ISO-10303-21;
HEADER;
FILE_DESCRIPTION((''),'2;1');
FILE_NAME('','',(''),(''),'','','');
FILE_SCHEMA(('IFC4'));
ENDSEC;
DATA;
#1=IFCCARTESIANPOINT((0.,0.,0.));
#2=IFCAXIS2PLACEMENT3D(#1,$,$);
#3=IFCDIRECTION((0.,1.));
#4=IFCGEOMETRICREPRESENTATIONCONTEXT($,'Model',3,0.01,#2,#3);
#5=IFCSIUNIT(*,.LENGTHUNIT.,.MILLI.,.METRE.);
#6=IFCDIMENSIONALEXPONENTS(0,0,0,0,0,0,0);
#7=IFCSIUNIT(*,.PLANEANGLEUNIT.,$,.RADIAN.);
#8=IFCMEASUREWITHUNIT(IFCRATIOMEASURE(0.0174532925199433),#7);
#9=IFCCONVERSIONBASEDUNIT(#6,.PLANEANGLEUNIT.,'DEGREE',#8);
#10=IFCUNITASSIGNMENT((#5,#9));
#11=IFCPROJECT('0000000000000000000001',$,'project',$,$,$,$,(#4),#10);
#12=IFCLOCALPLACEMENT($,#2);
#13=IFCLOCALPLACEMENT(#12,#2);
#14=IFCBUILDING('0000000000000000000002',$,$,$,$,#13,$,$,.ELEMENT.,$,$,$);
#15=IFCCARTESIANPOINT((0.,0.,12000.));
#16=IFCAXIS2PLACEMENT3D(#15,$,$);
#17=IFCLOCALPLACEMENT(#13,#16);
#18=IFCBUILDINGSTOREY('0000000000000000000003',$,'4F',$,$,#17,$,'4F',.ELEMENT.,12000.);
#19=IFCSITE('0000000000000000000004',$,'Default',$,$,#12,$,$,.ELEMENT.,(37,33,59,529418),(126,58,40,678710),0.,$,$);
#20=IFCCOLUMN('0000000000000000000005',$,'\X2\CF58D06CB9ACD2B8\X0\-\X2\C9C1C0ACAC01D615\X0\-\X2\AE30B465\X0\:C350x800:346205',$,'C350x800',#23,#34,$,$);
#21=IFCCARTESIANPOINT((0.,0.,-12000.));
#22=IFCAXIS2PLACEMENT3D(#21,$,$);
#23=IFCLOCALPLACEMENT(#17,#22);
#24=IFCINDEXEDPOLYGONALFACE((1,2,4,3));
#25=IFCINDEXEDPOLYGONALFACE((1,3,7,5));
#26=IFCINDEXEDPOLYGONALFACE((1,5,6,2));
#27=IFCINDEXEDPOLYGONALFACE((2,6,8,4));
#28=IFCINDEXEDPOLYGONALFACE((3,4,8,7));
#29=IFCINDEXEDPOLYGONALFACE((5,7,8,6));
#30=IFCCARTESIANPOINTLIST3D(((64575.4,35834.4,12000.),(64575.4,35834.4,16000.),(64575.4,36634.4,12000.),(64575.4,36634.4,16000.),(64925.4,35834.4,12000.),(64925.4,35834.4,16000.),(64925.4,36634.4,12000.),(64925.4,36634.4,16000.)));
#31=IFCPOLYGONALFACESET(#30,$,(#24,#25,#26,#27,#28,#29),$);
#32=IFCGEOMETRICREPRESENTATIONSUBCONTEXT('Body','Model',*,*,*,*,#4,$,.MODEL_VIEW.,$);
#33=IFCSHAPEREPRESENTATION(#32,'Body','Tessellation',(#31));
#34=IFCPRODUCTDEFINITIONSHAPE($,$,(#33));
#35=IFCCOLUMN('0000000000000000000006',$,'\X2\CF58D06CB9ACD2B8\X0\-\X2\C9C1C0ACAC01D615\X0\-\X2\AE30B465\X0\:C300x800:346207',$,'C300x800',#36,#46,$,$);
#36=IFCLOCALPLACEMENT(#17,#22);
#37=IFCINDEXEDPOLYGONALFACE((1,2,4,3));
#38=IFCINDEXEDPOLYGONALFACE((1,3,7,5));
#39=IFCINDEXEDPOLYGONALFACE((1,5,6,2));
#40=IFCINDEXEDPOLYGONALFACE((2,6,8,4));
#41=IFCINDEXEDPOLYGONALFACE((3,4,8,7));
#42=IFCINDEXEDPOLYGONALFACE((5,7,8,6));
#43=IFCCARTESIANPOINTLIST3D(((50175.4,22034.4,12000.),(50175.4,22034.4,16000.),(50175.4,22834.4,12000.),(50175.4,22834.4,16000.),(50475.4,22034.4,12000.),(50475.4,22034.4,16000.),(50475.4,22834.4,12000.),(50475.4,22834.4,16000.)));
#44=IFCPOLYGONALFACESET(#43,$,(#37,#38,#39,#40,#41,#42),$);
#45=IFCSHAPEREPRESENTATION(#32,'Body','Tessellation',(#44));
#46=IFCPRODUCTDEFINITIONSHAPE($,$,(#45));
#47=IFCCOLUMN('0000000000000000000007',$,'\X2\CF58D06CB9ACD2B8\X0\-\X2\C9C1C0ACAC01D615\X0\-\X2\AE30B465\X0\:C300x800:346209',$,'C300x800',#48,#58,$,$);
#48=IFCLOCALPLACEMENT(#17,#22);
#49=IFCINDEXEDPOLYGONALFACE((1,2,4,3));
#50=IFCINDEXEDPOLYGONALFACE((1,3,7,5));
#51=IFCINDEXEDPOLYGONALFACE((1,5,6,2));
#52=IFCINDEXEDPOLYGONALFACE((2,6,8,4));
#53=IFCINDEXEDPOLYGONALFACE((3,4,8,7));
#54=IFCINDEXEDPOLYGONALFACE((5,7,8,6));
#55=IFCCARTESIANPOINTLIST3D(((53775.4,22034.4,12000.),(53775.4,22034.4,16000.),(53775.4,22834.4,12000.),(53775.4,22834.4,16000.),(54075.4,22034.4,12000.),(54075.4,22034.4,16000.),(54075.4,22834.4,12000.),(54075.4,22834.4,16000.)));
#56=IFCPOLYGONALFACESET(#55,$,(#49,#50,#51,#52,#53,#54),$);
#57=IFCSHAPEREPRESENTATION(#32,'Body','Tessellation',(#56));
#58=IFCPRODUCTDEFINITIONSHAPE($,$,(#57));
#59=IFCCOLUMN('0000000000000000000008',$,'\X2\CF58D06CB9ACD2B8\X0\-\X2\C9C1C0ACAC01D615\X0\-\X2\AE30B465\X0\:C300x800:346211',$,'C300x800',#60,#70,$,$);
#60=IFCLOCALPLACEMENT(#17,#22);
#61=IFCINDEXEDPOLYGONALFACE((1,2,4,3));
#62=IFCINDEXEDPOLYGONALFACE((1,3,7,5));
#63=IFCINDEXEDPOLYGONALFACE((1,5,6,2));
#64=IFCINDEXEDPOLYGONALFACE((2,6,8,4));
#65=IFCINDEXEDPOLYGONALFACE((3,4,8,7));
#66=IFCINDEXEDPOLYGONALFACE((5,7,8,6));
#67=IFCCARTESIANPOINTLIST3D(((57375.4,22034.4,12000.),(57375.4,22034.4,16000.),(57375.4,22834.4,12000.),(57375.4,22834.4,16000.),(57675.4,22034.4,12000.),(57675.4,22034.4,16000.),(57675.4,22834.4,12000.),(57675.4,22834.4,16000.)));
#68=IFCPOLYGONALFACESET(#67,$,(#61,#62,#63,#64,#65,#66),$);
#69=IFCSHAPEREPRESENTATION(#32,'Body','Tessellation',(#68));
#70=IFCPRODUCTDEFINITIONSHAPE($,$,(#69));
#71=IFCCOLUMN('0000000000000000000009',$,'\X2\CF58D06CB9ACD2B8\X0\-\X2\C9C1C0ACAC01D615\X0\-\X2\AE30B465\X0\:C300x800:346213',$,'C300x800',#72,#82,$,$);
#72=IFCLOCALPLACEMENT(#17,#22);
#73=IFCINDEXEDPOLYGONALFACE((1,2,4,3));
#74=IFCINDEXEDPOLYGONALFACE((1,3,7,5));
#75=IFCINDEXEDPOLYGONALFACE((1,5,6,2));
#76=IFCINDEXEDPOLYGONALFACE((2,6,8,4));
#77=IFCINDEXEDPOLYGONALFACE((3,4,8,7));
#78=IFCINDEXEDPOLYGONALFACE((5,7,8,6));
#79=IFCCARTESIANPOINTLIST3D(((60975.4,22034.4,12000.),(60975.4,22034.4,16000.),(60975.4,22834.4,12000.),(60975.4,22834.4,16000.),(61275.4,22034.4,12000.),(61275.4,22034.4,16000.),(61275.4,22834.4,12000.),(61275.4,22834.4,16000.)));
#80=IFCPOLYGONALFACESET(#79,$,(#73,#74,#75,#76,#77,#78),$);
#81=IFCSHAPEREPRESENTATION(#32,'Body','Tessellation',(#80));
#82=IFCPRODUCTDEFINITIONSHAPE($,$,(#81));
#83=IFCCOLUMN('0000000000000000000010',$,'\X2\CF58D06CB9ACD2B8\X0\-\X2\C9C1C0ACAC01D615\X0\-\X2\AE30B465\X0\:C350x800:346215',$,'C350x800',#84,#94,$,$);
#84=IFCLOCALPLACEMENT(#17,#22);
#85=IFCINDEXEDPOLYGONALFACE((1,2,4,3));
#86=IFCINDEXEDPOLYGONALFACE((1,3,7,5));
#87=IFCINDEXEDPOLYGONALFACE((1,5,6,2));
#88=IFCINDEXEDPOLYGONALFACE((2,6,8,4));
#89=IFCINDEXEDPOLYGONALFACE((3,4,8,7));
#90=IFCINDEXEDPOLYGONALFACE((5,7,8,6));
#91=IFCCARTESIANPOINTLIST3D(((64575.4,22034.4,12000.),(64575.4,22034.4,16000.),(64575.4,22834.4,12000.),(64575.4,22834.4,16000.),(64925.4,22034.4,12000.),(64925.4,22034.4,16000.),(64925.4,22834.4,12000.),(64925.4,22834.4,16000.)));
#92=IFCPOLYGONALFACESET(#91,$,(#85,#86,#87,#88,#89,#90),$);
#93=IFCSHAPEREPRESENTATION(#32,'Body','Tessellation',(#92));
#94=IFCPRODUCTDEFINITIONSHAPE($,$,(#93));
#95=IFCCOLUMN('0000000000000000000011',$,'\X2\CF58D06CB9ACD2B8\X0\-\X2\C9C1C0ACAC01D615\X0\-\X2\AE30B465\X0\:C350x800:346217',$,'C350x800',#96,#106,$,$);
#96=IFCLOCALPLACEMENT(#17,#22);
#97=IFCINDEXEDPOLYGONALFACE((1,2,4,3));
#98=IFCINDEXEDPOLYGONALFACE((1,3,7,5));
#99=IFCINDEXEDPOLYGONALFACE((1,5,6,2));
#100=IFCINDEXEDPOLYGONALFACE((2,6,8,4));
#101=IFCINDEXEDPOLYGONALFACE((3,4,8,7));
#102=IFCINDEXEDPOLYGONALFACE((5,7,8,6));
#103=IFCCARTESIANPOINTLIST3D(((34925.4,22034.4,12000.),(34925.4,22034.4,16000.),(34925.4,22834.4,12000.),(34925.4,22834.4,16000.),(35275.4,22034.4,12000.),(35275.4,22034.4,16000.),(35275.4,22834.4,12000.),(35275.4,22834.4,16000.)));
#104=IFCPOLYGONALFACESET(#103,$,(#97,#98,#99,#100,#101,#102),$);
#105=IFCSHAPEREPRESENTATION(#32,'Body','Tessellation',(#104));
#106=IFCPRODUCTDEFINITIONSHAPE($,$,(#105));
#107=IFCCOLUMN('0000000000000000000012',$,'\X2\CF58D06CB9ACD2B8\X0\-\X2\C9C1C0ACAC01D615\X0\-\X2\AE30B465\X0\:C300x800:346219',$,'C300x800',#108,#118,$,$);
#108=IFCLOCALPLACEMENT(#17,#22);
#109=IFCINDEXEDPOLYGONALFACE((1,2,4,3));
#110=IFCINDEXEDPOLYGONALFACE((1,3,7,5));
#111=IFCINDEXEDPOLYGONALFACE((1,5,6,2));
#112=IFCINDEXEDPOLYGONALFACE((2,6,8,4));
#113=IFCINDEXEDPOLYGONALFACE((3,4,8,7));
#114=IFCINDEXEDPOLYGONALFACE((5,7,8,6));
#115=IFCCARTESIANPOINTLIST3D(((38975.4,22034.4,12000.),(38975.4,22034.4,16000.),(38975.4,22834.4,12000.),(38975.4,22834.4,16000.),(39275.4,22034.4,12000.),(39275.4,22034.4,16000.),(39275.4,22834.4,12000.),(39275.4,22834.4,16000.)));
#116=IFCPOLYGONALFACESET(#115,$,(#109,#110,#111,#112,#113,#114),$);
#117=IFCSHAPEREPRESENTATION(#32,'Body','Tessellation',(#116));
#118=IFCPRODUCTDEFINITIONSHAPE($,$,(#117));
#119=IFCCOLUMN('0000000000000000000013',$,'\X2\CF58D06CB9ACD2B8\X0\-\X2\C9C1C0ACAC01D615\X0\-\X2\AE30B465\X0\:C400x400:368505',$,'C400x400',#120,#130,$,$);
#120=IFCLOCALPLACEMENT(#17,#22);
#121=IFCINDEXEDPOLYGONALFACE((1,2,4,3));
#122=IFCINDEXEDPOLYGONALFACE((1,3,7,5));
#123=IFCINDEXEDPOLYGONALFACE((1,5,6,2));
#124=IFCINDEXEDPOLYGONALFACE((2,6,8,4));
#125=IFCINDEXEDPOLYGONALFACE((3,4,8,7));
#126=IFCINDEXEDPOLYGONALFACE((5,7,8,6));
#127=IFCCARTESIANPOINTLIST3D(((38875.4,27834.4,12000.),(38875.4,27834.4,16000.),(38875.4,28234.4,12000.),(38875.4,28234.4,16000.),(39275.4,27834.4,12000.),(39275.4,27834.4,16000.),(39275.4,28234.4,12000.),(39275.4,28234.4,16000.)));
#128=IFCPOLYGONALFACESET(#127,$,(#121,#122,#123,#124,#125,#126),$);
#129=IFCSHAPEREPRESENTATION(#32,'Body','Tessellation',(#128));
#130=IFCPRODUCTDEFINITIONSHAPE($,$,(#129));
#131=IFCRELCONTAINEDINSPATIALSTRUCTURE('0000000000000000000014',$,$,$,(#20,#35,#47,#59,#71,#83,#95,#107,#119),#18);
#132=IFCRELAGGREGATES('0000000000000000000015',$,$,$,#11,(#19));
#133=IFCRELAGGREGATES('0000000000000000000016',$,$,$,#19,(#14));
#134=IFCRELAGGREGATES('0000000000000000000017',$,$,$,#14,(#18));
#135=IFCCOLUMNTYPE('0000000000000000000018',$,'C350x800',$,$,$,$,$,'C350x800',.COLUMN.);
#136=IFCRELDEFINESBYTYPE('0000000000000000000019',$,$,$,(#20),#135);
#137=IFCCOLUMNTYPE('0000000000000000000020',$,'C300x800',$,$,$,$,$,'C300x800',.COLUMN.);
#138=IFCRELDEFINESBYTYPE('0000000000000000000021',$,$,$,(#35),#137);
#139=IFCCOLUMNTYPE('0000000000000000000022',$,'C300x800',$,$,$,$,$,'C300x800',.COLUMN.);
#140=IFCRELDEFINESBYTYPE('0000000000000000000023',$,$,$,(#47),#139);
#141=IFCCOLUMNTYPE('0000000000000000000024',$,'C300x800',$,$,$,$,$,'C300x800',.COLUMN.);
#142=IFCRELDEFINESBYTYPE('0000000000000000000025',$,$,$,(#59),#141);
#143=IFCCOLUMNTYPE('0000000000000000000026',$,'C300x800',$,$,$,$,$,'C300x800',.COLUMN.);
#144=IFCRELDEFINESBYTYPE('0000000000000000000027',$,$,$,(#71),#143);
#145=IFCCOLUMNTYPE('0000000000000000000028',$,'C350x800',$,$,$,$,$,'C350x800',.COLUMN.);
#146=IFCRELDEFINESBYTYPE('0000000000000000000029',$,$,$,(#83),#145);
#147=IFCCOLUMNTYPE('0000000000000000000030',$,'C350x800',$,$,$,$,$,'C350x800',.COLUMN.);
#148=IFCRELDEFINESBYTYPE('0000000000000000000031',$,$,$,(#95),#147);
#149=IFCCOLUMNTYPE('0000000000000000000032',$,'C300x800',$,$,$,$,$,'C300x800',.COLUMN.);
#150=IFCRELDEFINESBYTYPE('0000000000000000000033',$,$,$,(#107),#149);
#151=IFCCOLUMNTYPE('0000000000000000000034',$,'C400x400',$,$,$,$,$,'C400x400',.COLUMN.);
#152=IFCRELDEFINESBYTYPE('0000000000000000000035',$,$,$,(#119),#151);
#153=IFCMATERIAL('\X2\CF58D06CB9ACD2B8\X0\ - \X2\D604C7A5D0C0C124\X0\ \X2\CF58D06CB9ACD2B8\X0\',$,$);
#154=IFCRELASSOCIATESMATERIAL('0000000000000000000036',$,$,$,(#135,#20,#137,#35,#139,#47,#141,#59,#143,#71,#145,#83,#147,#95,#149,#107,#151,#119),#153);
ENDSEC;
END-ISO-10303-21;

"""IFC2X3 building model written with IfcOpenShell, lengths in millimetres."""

from ifc_helpers import new_model, entity, si_unit, converted_unit, direction, frame, frame_2d, origin, origin_2d_with_axis, place, context, subcontext, project, spatial, rectangle, extrude, source, transform, mapped, material, type_object, type_shapes, element, save


model = new_model("IFC2X3")

# Units and contexts
model_context = context("Model", 3, precision=0.01, world=origin(), true_north=direction((0.0, 1.0)))
body_context = subcontext(model_context, "Body", "Model", "MODEL_VIEW")
ifc_project = project(units=[si_unit("LENGTHUNIT", "METRE", prefix="MILLI"), converted_unit("PLANEANGLEUNIT", "DEGREE", entity("IfcRatioMeasure", 0.0174532925199433), si_unit("PLANEANGLEUNIT", "RADIAN"), dimensions=[0, 0, 0, 0, 0, 0, 0])], contexts=[model_context])

# Site, building, storey
site_placement = place(None, origin())
site = spatial("IfcSite", under=ifc_project, at=site_placement, Name="Default", CompositionType="ELEMENT", RefLatitude=(37, 33, 59, 529418), RefLongitude=(126, 58, 40, 678710), RefElevation=0.0)
building_placement = place(site_placement, origin())
building = spatial("IfcBuilding", under=site, at=building_placement, CompositionType="ELEMENT")
storey_placement = place(building_placement, frame((0.0, 0.0, 12000.0)))
storey = spatial("IfcBuildingStorey", under=building, at=storey_placement, Name="4F", LongName="4F", CompositionType="ELEMENT", Elevation=12000.0)

# Columns
ifc_material_1 = material(Name="콘크리트 - 현장타설 콘크리트")
column_type_1 = type_object("IfcColumnType", Name="C350x800", ElementType="C350x800", PredefinedType="COLUMN", material=ifc_material_1)
shared_shape_1 = source(origin(), body_context, "Body", "SweptSolid", [
    extrude(rectangle(XDim=800.0, YDim=350.0, at=frame_2d((0.0, 0.0), x_axis=(1.0, 0.0))), frame((64750.4, 36234.4, 12000.0), z_axis=(0.0, 0.0, 1.0), x_axis=(0.0, -1.0, 0.0)), (0.0, 0.0, 1.0), 4000.0),
])
type_shapes(column_type_1, [shared_shape_1])
column_1_placement = place(storey_placement, frame((0.0, 0.0, -12000.0)))
element("IfcColumn", 1, at=column_1_placement, inside=storey, type_object=column_type_1, material=ifc_material_1, Name="콘크리트-직사각형-기둥:C350x800:346205", ObjectType="C350x800", context=body_context, shape_type="MappedRepresentation", body=[
    mapped(shared_shape_1, transform((0.0, 0.0, 0.0), scale=1.0)),
])
column_type_2 = type_object("IfcColumnType", Name="C300x800", ElementType="C300x800", PredefinedType="COLUMN", material=ifc_material_1)
shared_shape_2 = source(origin(), body_context, "Body", "SweptSolid", [
    extrude(rectangle(XDim=800.0, YDim=300.0, at=origin_2d_with_axis()), frame((50325.4, 22434.4, 12000.0), z_axis=(0.0, 0.0, 1.0), x_axis=(0.0, -1.0, 0.0)), (0.0, 0.0, 1.0), 4000.0),
])
type_shapes(column_type_2, [shared_shape_2])
column_2_placement = place(storey_placement, frame((0.0, 0.0, -12000.0)))
element("IfcColumn", 2, at=column_2_placement, inside=storey, type_object=column_type_2, material=ifc_material_1, Name="콘크리트-직사각형-기둥:C300x800:346207", ObjectType="C300x800", context=body_context, shape_type="MappedRepresentation", body=[
    mapped(shared_shape_2, transform((0.0, 0.0, 0.0), scale=1.0)),
])
column_type_3 = type_object("IfcColumnType", Name="C300x800", ElementType="C300x800", PredefinedType="COLUMN", material=ifc_material_1)
shared_shape_3 = source(origin(), body_context, "Body", "SweptSolid", [
    extrude(rectangle(XDim=800.0, YDim=300.0, at=origin_2d_with_axis()), frame((53925.4, 22434.4, 12000.0), z_axis=(0.0, 0.0, 1.0), x_axis=(0.0, -1.0, 0.0)), (0.0, 0.0, 1.0), 4000.0),
])
type_shapes(column_type_3, [shared_shape_3])
column_3_placement = place(storey_placement, frame((0.0, 0.0, -12000.0)))
element("IfcColumn", 3, at=column_3_placement, inside=storey, type_object=column_type_3, material=ifc_material_1, Name="콘크리트-직사각형-기둥:C300x800:346209", ObjectType="C300x800", context=body_context, shape_type="MappedRepresentation", body=[
    mapped(shared_shape_3, transform((0.0, 0.0, 0.0), scale=1.0)),
])
column_type_4 = type_object("IfcColumnType", Name="C300x800", ElementType="C300x800", PredefinedType="COLUMN", material=ifc_material_1)
shared_shape_4 = source(origin(), body_context, "Body", "SweptSolid", [
    extrude(rectangle(XDim=800.0, YDim=300.0, at=origin_2d_with_axis()), frame((57525.4, 22434.4, 12000.0), z_axis=(0.0, 0.0, 1.0), x_axis=(0.0, -1.0, 0.0)), (0.0, 0.0, 1.0), 4000.0),
])
type_shapes(column_type_4, [shared_shape_4])
column_4_placement = place(storey_placement, frame((0.0, 0.0, -12000.0)))
element("IfcColumn", 4, at=column_4_placement, inside=storey, type_object=column_type_4, material=ifc_material_1, Name="콘크리트-직사각형-기둥:C300x800:346211", ObjectType="C300x800", context=body_context, shape_type="MappedRepresentation", body=[
    mapped(shared_shape_4, transform((0.0, 0.0, 0.0), scale=1.0)),
])
column_type_5 = type_object("IfcColumnType", Name="C300x800", ElementType="C300x800", PredefinedType="COLUMN", material=ifc_material_1)
shared_shape_5 = source(origin(), body_context, "Body", "SweptSolid", [
    extrude(rectangle(XDim=800.0, YDim=300.0, at=origin_2d_with_axis()), frame((61125.4, 22434.4, 12000.0), z_axis=(0.0, 0.0, 1.0), x_axis=(0.0, -1.0, 0.0)), (0.0, 0.0, 1.0), 4000.0),
])
type_shapes(column_type_5, [shared_shape_5])
column_5_placement = place(storey_placement, frame((0.0, 0.0, -12000.0)))
element("IfcColumn", 5, at=column_5_placement, inside=storey, type_object=column_type_5, material=ifc_material_1, Name="콘크리트-직사각형-기둥:C300x800:346213", ObjectType="C300x800", context=body_context, shape_type="MappedRepresentation", body=[
    mapped(shared_shape_5, transform((0.0, 0.0, 0.0), scale=1.0)),
])
column_type_6 = type_object("IfcColumnType", Name="C350x800", ElementType="C350x800", PredefinedType="COLUMN", material=ifc_material_1)
shared_shape_6 = source(origin(), body_context, "Body", "SweptSolid", [
    extrude(rectangle(XDim=800.0, YDim=350.0, at=origin_2d_with_axis()), frame((64750.4, 22434.4, 12000.0), z_axis=(0.0, 0.0, 1.0), x_axis=(0.0, -1.0, 0.0)), (0.0, 0.0, 1.0), 4000.0),
])
type_shapes(column_type_6, [shared_shape_6])
column_6_placement = place(storey_placement, frame((0.0, 0.0, -12000.0)))
element("IfcColumn", 6, at=column_6_placement, inside=storey, type_object=column_type_6, material=ifc_material_1, Name="콘크리트-직사각형-기둥:C350x800:346215", ObjectType="C350x800", context=body_context, shape_type="MappedRepresentation", body=[
    mapped(shared_shape_6, transform((0.0, 0.0, 0.0), scale=1.0)),
])
column_type_7 = type_object("IfcColumnType", Name="C350x800", ElementType="C350x800", PredefinedType="COLUMN", material=ifc_material_1)
shared_shape_7 = source(origin(), body_context, "Body", "SweptSolid", [
    extrude(rectangle(XDim=800.0, YDim=350.0, at=origin_2d_with_axis()), frame((35100.4, 22434.4, 12000.0), z_axis=(0.0, 0.0, 1.0), x_axis=(0.0, -1.0, 0.0)), (0.0, 0.0, 1.0), 4000.0),
])
type_shapes(column_type_7, [shared_shape_7])
column_7_placement = place(storey_placement, frame((0.0, 0.0, -12000.0)))
element("IfcColumn", 7, at=column_7_placement, inside=storey, type_object=column_type_7, material=ifc_material_1, Name="콘크리트-직사각형-기둥:C350x800:346217", ObjectType="C350x800", context=body_context, shape_type="MappedRepresentation", body=[
    mapped(shared_shape_7, transform((0.0, 0.0, 0.0), scale=1.0)),
])
column_type_8 = type_object("IfcColumnType", Name="C300x800", ElementType="C300x800", PredefinedType="COLUMN", material=ifc_material_1)
shared_shape_8 = source(origin(), body_context, "Body", "SweptSolid", [
    extrude(rectangle(XDim=800.0, YDim=300.0, at=origin_2d_with_axis()), frame((39125.4, 22434.4, 12000.0), z_axis=(0.0, 0.0, 1.0), x_axis=(0.0, -1.0, 0.0)), (0.0, 0.0, 1.0), 4000.0),
])
type_shapes(column_type_8, [shared_shape_8])
column_8_placement = place(storey_placement, frame((0.0, 0.0, -12000.0)))
element("IfcColumn", 8, at=column_8_placement, inside=storey, type_object=column_type_8, material=ifc_material_1, Name="콘크리트-직사각형-기둥:C300x800:346219", ObjectType="C300x800", context=body_context, shape_type="MappedRepresentation", body=[
    mapped(shared_shape_8, transform((0.0, 0.0, 0.0), scale=1.0)),
])
column_type_9 = type_object("IfcColumnType", Name="C400x400", ElementType="C400x400", PredefinedType="COLUMN", material=ifc_material_1)
shared_shape_9 = source(origin(), body_context, "Body", "SweptSolid", [
    extrude(rectangle(XDim=400.0, YDim=400.0, at=frame_2d((0.0, 0.0), x_axis=(1.0, 0.0))), frame((39075.4, 28034.4, 12000.0), z_axis=(0.0, 0.0, 1.0), x_axis=(0.0, -1.0, 0.0)), (0.0, 0.0, 1.0), 4000.0),
])
type_shapes(column_type_9, [shared_shape_9])
column_9_placement = place(storey_placement, frame((0.0, 0.0, -12000.0)))
element("IfcColumn", 9, at=column_9_placement, inside=storey, type_object=column_type_9, material=ifc_material_1, Name="콘크리트-직사각형-기둥:C400x400:368505", ObjectType="C400x400", context=body_context, shape_type="MappedRepresentation", body=[
    mapped(shared_shape_9, transform((0.0, 0.0, 0.0), scale=1.0)),
])

save(model, "model.ifc")
